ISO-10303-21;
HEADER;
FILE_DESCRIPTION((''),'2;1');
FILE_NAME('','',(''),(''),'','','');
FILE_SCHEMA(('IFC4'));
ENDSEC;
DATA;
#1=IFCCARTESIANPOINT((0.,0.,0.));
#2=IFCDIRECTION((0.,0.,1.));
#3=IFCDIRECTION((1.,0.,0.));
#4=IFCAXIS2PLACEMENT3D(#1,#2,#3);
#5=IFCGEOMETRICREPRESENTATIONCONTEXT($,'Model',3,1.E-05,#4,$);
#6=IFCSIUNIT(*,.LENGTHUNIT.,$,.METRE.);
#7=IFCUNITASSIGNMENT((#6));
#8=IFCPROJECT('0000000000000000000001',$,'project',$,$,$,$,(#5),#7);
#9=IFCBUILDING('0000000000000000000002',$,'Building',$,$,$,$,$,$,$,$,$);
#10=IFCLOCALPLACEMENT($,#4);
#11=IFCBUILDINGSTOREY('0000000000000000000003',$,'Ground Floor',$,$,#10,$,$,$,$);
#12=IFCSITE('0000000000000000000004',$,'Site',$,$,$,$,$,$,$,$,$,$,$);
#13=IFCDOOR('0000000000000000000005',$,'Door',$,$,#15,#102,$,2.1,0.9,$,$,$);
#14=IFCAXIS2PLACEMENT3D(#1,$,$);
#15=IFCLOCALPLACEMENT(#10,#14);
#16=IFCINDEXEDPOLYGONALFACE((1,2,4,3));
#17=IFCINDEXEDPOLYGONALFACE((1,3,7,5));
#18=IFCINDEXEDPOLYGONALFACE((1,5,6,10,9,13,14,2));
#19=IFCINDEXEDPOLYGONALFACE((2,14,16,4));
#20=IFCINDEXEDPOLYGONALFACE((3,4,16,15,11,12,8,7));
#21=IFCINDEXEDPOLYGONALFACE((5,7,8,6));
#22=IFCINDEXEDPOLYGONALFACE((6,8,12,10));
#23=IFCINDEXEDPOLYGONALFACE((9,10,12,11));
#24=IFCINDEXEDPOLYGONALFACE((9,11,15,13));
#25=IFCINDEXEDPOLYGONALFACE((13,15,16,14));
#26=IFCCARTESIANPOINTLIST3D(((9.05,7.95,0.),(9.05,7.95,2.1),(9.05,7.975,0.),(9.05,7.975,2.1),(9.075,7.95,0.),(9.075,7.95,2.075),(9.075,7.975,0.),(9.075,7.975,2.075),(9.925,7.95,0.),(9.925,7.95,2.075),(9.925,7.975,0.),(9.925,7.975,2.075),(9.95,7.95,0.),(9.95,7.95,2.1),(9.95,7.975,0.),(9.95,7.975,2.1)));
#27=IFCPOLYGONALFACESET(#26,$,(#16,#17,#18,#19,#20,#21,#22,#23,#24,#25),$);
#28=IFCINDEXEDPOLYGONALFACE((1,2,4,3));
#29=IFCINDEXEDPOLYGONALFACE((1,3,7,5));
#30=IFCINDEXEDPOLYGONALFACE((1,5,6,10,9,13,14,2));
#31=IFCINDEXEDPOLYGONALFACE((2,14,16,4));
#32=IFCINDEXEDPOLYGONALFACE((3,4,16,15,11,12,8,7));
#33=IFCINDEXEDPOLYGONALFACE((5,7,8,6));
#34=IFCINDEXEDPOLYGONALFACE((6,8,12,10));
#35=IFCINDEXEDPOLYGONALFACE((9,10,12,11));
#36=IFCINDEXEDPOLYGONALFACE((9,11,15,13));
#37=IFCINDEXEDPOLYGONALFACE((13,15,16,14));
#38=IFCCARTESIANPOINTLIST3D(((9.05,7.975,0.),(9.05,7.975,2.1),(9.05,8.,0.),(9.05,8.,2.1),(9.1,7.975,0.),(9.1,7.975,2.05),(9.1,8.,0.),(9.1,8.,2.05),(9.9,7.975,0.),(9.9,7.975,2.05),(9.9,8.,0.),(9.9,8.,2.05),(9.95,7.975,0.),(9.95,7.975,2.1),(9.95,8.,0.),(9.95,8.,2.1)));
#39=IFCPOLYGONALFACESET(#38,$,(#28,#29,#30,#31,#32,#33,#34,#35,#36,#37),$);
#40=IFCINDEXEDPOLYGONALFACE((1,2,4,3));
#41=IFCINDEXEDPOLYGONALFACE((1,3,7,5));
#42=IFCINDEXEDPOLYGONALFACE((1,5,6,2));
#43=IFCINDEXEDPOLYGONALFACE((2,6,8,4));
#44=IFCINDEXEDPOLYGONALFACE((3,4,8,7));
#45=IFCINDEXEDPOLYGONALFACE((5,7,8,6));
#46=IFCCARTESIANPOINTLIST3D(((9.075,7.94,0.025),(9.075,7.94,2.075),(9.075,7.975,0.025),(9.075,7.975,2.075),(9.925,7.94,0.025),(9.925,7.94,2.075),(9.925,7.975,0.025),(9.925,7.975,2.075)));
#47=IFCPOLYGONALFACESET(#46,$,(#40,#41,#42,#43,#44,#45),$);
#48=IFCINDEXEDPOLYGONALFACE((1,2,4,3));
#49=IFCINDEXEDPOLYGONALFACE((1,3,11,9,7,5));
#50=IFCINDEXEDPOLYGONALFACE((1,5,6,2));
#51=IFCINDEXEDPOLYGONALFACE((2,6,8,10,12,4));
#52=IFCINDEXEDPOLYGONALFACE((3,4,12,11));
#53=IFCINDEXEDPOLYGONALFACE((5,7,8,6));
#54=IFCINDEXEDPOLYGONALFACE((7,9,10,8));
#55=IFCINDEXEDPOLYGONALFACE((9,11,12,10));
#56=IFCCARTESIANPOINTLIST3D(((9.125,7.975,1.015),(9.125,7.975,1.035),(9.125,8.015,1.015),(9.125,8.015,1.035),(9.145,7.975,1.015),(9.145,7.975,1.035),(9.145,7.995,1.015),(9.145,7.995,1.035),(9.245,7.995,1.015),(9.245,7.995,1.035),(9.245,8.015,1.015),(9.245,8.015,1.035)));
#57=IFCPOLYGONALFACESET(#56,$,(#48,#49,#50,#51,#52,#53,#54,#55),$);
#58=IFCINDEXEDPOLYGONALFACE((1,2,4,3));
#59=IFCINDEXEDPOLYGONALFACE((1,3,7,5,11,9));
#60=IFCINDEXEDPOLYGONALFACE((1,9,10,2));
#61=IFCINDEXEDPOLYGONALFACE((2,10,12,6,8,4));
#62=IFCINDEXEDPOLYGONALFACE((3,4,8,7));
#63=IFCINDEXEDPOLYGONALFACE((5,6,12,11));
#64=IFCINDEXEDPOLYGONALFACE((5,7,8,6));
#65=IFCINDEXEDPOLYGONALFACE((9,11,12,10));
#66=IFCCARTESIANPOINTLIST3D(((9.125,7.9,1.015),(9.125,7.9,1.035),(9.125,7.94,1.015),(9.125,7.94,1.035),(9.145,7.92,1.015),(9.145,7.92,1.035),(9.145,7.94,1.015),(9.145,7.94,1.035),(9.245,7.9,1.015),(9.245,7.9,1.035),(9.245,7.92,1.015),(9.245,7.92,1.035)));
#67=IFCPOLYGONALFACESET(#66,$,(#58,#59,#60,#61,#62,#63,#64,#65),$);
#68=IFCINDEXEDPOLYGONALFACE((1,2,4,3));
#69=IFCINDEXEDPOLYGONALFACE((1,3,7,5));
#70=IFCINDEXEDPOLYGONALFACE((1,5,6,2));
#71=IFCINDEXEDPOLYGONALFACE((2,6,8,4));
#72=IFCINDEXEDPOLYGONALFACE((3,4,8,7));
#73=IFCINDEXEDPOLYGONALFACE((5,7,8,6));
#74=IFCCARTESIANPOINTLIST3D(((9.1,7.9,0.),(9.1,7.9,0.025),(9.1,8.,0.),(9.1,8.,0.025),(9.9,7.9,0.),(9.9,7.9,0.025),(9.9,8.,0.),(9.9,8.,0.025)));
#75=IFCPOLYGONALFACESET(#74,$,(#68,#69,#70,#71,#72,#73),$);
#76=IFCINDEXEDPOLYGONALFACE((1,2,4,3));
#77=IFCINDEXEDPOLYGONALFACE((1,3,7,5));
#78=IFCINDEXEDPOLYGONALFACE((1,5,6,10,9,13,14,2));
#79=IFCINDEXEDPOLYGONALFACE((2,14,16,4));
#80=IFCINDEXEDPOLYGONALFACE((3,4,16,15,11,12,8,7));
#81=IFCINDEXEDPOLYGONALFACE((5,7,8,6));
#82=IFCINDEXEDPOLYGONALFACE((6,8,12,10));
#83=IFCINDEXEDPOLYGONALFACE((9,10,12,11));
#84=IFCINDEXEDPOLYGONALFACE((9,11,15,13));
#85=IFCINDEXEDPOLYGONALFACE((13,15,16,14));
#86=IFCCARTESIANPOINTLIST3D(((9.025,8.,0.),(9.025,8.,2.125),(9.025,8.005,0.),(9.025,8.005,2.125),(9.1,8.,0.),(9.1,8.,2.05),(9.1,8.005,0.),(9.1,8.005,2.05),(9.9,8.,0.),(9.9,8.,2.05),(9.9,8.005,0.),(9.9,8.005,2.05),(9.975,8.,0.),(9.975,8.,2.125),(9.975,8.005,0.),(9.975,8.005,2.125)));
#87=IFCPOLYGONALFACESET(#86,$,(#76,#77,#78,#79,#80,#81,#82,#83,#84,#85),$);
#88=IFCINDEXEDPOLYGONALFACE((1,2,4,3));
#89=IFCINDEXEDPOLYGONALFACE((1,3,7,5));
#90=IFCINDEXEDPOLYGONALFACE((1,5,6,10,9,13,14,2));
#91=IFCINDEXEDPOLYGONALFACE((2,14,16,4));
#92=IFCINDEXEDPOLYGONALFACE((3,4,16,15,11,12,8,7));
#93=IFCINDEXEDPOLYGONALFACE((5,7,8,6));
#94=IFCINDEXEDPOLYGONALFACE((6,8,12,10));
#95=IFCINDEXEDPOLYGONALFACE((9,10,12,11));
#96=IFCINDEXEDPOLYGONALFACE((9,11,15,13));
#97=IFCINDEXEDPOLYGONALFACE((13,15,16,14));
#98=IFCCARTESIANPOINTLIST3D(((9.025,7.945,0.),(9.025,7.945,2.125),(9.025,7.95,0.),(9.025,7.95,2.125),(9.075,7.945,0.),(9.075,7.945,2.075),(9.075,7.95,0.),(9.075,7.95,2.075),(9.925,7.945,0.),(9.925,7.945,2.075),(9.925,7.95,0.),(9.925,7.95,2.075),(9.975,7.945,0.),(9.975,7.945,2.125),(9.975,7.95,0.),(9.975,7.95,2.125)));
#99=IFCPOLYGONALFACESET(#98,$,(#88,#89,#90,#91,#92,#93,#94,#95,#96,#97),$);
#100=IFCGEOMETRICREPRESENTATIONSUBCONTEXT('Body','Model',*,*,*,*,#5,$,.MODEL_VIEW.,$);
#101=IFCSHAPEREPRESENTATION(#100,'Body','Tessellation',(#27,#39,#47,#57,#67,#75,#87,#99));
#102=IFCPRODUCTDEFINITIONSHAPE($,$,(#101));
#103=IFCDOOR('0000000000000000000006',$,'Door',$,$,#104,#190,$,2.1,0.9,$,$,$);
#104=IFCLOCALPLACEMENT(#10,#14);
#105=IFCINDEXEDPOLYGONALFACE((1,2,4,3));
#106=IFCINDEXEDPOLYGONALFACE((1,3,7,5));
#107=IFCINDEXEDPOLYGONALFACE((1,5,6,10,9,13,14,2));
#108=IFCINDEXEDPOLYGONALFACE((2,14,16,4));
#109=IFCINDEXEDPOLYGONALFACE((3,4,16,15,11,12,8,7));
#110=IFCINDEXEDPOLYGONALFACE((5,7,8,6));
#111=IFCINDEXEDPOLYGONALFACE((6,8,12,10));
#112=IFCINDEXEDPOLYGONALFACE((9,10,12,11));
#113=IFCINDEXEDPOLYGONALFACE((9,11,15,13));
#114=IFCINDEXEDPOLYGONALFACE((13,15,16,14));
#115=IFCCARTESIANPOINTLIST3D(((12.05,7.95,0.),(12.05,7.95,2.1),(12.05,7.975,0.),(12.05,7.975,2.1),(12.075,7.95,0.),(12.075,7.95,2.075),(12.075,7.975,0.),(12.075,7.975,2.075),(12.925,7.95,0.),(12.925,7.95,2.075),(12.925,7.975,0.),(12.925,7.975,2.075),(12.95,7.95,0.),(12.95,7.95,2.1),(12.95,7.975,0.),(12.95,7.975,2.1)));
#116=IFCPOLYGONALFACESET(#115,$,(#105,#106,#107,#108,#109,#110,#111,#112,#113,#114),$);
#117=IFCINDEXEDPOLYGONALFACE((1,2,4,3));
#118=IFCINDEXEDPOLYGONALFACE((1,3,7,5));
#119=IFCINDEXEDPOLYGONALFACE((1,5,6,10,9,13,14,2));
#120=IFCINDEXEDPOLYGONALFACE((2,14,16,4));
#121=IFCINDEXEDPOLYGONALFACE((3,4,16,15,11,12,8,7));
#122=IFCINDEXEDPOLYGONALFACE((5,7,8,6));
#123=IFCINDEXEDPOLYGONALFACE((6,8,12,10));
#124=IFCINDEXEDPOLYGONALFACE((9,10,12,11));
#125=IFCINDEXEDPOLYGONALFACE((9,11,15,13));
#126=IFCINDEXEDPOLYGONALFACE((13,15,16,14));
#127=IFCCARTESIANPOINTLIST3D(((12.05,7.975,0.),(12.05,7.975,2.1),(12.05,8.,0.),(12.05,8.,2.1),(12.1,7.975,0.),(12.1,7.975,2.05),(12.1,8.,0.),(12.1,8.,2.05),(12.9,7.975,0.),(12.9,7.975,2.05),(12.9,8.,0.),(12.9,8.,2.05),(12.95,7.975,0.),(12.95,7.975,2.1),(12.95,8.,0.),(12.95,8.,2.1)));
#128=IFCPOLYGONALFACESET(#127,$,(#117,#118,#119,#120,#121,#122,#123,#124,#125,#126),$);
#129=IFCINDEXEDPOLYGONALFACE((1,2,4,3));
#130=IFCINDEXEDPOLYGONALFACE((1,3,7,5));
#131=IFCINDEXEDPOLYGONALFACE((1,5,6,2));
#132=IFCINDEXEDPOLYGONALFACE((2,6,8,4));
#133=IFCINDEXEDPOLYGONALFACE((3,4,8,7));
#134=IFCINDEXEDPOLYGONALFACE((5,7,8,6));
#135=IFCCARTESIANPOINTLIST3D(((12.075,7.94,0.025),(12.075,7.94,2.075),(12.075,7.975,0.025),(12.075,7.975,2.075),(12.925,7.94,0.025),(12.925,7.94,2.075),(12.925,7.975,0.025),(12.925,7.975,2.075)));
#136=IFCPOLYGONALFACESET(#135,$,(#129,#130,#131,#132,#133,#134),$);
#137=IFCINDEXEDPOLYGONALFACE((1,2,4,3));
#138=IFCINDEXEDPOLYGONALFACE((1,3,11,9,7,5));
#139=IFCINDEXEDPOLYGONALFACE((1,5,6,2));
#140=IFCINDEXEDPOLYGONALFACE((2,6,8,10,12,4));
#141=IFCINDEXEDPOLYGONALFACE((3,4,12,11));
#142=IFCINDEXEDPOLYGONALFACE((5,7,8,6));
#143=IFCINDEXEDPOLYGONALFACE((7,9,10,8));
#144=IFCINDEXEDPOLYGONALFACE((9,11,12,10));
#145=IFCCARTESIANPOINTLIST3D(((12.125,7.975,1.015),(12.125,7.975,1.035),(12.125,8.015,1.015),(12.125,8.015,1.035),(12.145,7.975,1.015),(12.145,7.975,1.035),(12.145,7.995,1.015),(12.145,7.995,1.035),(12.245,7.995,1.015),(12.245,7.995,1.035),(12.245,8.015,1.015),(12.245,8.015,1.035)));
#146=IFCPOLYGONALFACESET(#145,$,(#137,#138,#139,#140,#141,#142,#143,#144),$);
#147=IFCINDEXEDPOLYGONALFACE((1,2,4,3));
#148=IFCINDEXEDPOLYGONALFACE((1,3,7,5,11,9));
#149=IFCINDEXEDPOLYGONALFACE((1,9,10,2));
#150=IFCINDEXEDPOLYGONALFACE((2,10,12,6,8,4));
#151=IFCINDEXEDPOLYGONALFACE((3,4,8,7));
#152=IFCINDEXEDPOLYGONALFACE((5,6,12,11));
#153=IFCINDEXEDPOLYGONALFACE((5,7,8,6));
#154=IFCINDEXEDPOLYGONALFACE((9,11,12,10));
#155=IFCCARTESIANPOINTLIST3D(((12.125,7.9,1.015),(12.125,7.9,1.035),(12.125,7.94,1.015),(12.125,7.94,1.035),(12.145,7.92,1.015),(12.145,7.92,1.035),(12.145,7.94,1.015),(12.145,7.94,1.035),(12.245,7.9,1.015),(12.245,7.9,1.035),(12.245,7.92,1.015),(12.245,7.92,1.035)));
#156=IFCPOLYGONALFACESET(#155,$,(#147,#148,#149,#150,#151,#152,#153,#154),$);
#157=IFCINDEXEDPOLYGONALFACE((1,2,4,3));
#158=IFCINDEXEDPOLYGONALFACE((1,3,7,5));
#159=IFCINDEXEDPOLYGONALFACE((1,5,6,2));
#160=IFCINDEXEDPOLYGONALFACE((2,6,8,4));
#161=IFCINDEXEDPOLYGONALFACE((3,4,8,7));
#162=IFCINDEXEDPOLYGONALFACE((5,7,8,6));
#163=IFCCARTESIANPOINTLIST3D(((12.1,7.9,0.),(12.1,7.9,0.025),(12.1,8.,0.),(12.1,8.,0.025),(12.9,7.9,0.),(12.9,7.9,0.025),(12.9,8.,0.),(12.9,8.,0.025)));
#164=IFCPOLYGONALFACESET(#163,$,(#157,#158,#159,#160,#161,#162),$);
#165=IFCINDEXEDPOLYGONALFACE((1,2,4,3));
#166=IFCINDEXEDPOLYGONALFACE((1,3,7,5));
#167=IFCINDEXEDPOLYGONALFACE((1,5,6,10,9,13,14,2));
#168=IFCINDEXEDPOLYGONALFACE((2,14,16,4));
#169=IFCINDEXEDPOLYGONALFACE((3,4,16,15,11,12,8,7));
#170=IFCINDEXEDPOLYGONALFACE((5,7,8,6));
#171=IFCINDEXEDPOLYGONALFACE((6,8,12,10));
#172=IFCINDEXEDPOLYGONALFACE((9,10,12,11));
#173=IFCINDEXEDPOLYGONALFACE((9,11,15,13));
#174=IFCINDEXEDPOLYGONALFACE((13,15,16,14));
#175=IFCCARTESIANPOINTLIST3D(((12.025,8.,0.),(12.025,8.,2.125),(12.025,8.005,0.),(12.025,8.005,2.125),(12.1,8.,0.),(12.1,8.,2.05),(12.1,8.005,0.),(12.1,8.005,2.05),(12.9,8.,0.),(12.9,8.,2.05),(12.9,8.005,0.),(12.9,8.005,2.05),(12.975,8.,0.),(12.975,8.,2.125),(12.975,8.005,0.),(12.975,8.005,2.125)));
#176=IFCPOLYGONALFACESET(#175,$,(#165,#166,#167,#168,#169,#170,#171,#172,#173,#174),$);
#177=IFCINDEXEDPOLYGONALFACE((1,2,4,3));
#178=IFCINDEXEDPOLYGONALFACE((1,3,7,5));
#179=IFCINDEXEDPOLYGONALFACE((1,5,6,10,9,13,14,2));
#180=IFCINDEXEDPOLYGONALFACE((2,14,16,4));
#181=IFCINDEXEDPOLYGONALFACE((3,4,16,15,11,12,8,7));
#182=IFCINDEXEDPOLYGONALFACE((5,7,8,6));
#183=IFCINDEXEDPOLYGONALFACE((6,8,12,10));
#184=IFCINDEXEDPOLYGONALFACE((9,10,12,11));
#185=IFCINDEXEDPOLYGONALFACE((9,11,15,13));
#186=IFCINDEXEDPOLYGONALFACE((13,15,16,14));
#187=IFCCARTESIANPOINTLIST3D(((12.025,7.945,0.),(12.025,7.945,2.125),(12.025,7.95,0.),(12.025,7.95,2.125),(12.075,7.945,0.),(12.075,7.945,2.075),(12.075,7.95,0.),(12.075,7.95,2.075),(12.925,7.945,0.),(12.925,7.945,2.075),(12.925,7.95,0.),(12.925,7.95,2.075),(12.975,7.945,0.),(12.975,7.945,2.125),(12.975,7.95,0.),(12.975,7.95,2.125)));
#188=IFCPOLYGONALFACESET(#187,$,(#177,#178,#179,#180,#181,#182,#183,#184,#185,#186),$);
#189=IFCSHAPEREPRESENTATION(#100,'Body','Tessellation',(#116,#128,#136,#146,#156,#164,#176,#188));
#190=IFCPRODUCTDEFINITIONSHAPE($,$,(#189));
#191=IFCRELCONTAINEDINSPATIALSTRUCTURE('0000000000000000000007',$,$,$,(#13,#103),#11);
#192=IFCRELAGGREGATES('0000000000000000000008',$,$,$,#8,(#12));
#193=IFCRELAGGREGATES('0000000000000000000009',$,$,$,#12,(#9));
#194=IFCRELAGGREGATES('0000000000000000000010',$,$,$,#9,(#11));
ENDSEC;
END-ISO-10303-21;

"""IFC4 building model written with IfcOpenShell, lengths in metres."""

from ifc_helpers import new_model, si_unit, frame, origin_with_axes, place, context, subcontext, project, spatial, line, indexed_curve, outline, extrude, element, save


model = new_model("IFC4")

# Units and contexts
model_context = context("Model", 3, precision=1e-05, world=origin_with_axes())
body_context = subcontext(model_context, "Body", "Model", "MODEL_VIEW")
ifc_project = project(units=[si_unit("LENGTHUNIT", "METRE")], contexts=[model_context])

# Site, building, storey
site = spatial("IfcSite", under=ifc_project, Name="Site")
building = spatial("IfcBuilding", under=site, Name="Building")
storey_placement = place(None, origin_with_axes())
storey = spatial("IfcBuildingStorey", under=building, at=storey_placement, Name="Ground Floor")

# Doors
door_1_placement = place(storey_placement, frame((9.95, 8.0, 0.0), z_axis=(0.0, 0.0, 1.0), x_axis=(-1.0, 0.0, 0.0)))
element("IfcDoor", 1, at=door_1_placement, inside=storey, Name="Door", OverallHeight=2.1, OverallWidth=0.9, context=body_context, shape_type="SweptSolid", body=[
    extrude(outline(indexed_curve([(0.0, 0.0), (0.0, 2.1), (0.9, 2.1), (0.9, 0.0), (0.875, 0.0), (0.875, 2.075), (0.025, 2.075), (0.025, 0.0)], segments=[line(1, 2, 3, 4, 5, 6, 7, 8, 1)])), frame((0.0, 0.025, 0.0), z_axis=(0.0, -1.0, 0.0), x_axis=(1.0, 0.0, 0.0)), (0.0, 0.0, -1.0), 0.025),
    extrude(outline(indexed_curve([(0.0, 0.0), (0.0, 2.1), (0.9, 2.1), (0.9, 0.0), (0.85, 0.0), (0.85, 2.05), (0.05, 2.05), (0.05, 0.0)], segments=[line(1, 2, 3, 4, 5, 6, 7, 8, 1)])), frame((0.0, 0.0, 0.0), z_axis=(0.0, -1.0, 0.0), x_axis=(1.0, 0.0, 0.0)), (0.0, 0.0, -1.0), 0.025),
    extrude(outline(indexed_curve([(0.0, 0.0), (0.85, 0.0), (0.85, 0.035), (0.0, 0.035)], segments=[line(1, 2, 3, 4, 1)])), frame((0.025, 0.025, 0.025), z_axis=(0.0, 0.0, 1.0), x_axis=(1.0, 0.0, 0.0)), (0.0, 0.0, 1.0), 2.05),
    extrude(outline(indexed_curve([(0.0, 0.0), (0.0, -0.04), (-0.12, -0.04), (-0.12, -0.02), (-0.02, -0.02), (-0.02, 0.0)], segments=[line(1, 2, 3, 4, 5, 6, 1)])), frame((0.825, 0.025, 1.015), z_axis=(0.0, 0.0, 1.0), x_axis=(1.0, 0.0, 0.0)), (0.0, 0.0, 1.0), 0.02),
    extrude(outline(indexed_curve([(0.0, 0.0), (0.0, 0.04), (-0.12, 0.04), (-0.12, 0.02), (-0.02, 0.02), (-0.02, 0.0)], segments=[line(1, 2, 3, 4, 5, 6, 1)])), frame((0.825, 0.06, 1.015), z_axis=(0.0, 0.0, 1.0), x_axis=(1.0, 0.0, 0.0)), (0.0, 0.0, 1.0), 0.02),
    extrude(outline(indexed_curve([(0.0, 0.0), (0.8, 0.0), (0.8, 0.1), (0.0, 0.1)], segments=[line(1, 2, 3, 4, 1)])), frame((0.05, 0.0, 0.0), z_axis=(0.0, 0.0, 1.0), x_axis=(1.0, 0.0, 0.0)), (0.0, 0.0, 1.0), 0.025),
    extrude(outline(indexed_curve([(0.0, 0.0), (0.0, 2.125), (0.95, 2.125), (0.95, 0.0), (0.875, 0.0), (0.875, 2.05), (0.075, 2.05), (0.075, 0.0)], segments=[line(1, 2, 3, 4, 5, 6, 7, 8, 1)])), frame((-0.025, -0.005, 0.0), z_axis=(0.0, -1.0, 0.0), x_axis=(1.0, 0.0, 0.0)), (0.0, 0.0, -1.0), 0.005),
    extrude(outline(indexed_curve([(0.0, 0.0), (0.0, 2.125), (0.95, 2.125), (0.95, 0.0), (0.9, 0.0), (0.9, 2.075), (0.05, 2.075), (0.05, 0.0)], segments=[line(1, 2, 3, 4, 5, 6, 7, 8, 1)])), frame((-0.025, 0.05, 0.0), z_axis=(0.0, -1.0, 0.0), x_axis=(1.0, 0.0, 0.0)), (0.0, 0.0, -1.0), 0.005),
])
door_2_placement = place(storey_placement, frame((12.95, 8.0, 0.0), z_axis=(0.0, 0.0, 1.0), x_axis=(-1.0, 0.0, 0.0)))
element("IfcDoor", 2, at=door_2_placement, inside=storey, Name="Door", OverallHeight=2.1, OverallWidth=0.9, context=body_context, shape_type="SweptSolid", body=[
    extrude(outline(indexed_curve([(0.0, 0.0), (0.0, 2.1), (0.9, 2.1), (0.9, 0.0), (0.875, 0.0), (0.875, 2.075), (0.025, 2.075), (0.025, 0.0)], segments=[line(1, 2, 3, 4, 5, 6, 7, 8, 1)])), frame((0.0, 0.025, 0.0), z_axis=(0.0, -1.0, 0.0), x_axis=(1.0, 0.0, 0.0)), (0.0, 0.0, -1.0), 0.025),
    extrude(outline(indexed_curve([(0.0, 0.0), (0.0, 2.1), (0.9, 2.1), (0.9, 0.0), (0.85, 0.0), (0.85, 2.05), (0.05, 2.05), (0.05, 0.0)], segments=[line(1, 2, 3, 4, 5, 6, 7, 8, 1)])), frame((0.0, 0.0, 0.0), z_axis=(0.0, -1.0, 0.0), x_axis=(1.0, 0.0, 0.0)), (0.0, 0.0, -1.0), 0.025),
    extrude(outline(indexed_curve([(0.0, 0.0), (0.85, 0.0), (0.85, 0.035), (0.0, 0.035)], segments=[line(1, 2, 3, 4, 1)])), frame((0.025, 0.025, 0.025), z_axis=(0.0, 0.0, 1.0), x_axis=(1.0, 0.0, 0.0)), (0.0, 0.0, 1.0), 2.05),
    extrude(outline(indexed_curve([(0.0, 0.0), (0.0, -0.04), (-0.12, -0.04), (-0.12, -0.02), (-0.02, -0.02), (-0.02, 0.0)], segments=[line(1, 2, 3, 4, 5, 6, 1)])), frame((0.825, 0.025, 1.015), z_axis=(0.0, 0.0, 1.0), x_axis=(1.0, 0.0, 0.0)), (0.0, 0.0, 1.0), 0.02),
    extrude(outline(indexed_curve([(0.0, 0.0), (0.0, 0.04), (-0.12, 0.04), (-0.12, 0.02), (-0.02, 0.02), (-0.02, 0.0)], segments=[line(1, 2, 3, 4, 5, 6, 1)])), frame((0.825, 0.06, 1.015), z_axis=(0.0, 0.0, 1.0), x_axis=(1.0, 0.0, 0.0)), (0.0, 0.0, 1.0), 0.02),
    extrude(outline(indexed_curve([(0.0, 0.0), (0.8, 0.0), (0.8, 0.1), (0.0, 0.1)], segments=[line(1, 2, 3, 4, 1)])), frame((0.05, 0.0, 0.0), z_axis=(0.0, 0.0, 1.0), x_axis=(1.0, 0.0, 0.0)), (0.0, 0.0, 1.0), 0.025),
    extrude(outline(indexed_curve([(0.0, 0.0), (0.0, 2.125), (0.95, 2.125), (0.95, 0.0), (0.875, 0.0), (0.875, 2.05), (0.075, 2.05), (0.075, 0.0)], segments=[line(1, 2, 3, 4, 5, 6, 7, 8, 1)])), frame((-0.025, -0.005, 0.0), z_axis=(0.0, -1.0, 0.0), x_axis=(1.0, 0.0, 0.0)), (0.0, 0.0, -1.0), 0.005),
    extrude(outline(indexed_curve([(0.0, 0.0), (0.0, 2.125), (0.95, 2.125), (0.95, 0.0), (0.9, 0.0), (0.9, 2.075), (0.05, 2.075), (0.05, 0.0)], segments=[line(1, 2, 3, 4, 5, 6, 7, 8, 1)])), frame((-0.025, 0.05, 0.0), z_axis=(0.0, -1.0, 0.0), x_axis=(1.0, 0.0, 0.0)), (0.0, 0.0, -1.0), 0.005),
])

save(model, "model.ifc")
